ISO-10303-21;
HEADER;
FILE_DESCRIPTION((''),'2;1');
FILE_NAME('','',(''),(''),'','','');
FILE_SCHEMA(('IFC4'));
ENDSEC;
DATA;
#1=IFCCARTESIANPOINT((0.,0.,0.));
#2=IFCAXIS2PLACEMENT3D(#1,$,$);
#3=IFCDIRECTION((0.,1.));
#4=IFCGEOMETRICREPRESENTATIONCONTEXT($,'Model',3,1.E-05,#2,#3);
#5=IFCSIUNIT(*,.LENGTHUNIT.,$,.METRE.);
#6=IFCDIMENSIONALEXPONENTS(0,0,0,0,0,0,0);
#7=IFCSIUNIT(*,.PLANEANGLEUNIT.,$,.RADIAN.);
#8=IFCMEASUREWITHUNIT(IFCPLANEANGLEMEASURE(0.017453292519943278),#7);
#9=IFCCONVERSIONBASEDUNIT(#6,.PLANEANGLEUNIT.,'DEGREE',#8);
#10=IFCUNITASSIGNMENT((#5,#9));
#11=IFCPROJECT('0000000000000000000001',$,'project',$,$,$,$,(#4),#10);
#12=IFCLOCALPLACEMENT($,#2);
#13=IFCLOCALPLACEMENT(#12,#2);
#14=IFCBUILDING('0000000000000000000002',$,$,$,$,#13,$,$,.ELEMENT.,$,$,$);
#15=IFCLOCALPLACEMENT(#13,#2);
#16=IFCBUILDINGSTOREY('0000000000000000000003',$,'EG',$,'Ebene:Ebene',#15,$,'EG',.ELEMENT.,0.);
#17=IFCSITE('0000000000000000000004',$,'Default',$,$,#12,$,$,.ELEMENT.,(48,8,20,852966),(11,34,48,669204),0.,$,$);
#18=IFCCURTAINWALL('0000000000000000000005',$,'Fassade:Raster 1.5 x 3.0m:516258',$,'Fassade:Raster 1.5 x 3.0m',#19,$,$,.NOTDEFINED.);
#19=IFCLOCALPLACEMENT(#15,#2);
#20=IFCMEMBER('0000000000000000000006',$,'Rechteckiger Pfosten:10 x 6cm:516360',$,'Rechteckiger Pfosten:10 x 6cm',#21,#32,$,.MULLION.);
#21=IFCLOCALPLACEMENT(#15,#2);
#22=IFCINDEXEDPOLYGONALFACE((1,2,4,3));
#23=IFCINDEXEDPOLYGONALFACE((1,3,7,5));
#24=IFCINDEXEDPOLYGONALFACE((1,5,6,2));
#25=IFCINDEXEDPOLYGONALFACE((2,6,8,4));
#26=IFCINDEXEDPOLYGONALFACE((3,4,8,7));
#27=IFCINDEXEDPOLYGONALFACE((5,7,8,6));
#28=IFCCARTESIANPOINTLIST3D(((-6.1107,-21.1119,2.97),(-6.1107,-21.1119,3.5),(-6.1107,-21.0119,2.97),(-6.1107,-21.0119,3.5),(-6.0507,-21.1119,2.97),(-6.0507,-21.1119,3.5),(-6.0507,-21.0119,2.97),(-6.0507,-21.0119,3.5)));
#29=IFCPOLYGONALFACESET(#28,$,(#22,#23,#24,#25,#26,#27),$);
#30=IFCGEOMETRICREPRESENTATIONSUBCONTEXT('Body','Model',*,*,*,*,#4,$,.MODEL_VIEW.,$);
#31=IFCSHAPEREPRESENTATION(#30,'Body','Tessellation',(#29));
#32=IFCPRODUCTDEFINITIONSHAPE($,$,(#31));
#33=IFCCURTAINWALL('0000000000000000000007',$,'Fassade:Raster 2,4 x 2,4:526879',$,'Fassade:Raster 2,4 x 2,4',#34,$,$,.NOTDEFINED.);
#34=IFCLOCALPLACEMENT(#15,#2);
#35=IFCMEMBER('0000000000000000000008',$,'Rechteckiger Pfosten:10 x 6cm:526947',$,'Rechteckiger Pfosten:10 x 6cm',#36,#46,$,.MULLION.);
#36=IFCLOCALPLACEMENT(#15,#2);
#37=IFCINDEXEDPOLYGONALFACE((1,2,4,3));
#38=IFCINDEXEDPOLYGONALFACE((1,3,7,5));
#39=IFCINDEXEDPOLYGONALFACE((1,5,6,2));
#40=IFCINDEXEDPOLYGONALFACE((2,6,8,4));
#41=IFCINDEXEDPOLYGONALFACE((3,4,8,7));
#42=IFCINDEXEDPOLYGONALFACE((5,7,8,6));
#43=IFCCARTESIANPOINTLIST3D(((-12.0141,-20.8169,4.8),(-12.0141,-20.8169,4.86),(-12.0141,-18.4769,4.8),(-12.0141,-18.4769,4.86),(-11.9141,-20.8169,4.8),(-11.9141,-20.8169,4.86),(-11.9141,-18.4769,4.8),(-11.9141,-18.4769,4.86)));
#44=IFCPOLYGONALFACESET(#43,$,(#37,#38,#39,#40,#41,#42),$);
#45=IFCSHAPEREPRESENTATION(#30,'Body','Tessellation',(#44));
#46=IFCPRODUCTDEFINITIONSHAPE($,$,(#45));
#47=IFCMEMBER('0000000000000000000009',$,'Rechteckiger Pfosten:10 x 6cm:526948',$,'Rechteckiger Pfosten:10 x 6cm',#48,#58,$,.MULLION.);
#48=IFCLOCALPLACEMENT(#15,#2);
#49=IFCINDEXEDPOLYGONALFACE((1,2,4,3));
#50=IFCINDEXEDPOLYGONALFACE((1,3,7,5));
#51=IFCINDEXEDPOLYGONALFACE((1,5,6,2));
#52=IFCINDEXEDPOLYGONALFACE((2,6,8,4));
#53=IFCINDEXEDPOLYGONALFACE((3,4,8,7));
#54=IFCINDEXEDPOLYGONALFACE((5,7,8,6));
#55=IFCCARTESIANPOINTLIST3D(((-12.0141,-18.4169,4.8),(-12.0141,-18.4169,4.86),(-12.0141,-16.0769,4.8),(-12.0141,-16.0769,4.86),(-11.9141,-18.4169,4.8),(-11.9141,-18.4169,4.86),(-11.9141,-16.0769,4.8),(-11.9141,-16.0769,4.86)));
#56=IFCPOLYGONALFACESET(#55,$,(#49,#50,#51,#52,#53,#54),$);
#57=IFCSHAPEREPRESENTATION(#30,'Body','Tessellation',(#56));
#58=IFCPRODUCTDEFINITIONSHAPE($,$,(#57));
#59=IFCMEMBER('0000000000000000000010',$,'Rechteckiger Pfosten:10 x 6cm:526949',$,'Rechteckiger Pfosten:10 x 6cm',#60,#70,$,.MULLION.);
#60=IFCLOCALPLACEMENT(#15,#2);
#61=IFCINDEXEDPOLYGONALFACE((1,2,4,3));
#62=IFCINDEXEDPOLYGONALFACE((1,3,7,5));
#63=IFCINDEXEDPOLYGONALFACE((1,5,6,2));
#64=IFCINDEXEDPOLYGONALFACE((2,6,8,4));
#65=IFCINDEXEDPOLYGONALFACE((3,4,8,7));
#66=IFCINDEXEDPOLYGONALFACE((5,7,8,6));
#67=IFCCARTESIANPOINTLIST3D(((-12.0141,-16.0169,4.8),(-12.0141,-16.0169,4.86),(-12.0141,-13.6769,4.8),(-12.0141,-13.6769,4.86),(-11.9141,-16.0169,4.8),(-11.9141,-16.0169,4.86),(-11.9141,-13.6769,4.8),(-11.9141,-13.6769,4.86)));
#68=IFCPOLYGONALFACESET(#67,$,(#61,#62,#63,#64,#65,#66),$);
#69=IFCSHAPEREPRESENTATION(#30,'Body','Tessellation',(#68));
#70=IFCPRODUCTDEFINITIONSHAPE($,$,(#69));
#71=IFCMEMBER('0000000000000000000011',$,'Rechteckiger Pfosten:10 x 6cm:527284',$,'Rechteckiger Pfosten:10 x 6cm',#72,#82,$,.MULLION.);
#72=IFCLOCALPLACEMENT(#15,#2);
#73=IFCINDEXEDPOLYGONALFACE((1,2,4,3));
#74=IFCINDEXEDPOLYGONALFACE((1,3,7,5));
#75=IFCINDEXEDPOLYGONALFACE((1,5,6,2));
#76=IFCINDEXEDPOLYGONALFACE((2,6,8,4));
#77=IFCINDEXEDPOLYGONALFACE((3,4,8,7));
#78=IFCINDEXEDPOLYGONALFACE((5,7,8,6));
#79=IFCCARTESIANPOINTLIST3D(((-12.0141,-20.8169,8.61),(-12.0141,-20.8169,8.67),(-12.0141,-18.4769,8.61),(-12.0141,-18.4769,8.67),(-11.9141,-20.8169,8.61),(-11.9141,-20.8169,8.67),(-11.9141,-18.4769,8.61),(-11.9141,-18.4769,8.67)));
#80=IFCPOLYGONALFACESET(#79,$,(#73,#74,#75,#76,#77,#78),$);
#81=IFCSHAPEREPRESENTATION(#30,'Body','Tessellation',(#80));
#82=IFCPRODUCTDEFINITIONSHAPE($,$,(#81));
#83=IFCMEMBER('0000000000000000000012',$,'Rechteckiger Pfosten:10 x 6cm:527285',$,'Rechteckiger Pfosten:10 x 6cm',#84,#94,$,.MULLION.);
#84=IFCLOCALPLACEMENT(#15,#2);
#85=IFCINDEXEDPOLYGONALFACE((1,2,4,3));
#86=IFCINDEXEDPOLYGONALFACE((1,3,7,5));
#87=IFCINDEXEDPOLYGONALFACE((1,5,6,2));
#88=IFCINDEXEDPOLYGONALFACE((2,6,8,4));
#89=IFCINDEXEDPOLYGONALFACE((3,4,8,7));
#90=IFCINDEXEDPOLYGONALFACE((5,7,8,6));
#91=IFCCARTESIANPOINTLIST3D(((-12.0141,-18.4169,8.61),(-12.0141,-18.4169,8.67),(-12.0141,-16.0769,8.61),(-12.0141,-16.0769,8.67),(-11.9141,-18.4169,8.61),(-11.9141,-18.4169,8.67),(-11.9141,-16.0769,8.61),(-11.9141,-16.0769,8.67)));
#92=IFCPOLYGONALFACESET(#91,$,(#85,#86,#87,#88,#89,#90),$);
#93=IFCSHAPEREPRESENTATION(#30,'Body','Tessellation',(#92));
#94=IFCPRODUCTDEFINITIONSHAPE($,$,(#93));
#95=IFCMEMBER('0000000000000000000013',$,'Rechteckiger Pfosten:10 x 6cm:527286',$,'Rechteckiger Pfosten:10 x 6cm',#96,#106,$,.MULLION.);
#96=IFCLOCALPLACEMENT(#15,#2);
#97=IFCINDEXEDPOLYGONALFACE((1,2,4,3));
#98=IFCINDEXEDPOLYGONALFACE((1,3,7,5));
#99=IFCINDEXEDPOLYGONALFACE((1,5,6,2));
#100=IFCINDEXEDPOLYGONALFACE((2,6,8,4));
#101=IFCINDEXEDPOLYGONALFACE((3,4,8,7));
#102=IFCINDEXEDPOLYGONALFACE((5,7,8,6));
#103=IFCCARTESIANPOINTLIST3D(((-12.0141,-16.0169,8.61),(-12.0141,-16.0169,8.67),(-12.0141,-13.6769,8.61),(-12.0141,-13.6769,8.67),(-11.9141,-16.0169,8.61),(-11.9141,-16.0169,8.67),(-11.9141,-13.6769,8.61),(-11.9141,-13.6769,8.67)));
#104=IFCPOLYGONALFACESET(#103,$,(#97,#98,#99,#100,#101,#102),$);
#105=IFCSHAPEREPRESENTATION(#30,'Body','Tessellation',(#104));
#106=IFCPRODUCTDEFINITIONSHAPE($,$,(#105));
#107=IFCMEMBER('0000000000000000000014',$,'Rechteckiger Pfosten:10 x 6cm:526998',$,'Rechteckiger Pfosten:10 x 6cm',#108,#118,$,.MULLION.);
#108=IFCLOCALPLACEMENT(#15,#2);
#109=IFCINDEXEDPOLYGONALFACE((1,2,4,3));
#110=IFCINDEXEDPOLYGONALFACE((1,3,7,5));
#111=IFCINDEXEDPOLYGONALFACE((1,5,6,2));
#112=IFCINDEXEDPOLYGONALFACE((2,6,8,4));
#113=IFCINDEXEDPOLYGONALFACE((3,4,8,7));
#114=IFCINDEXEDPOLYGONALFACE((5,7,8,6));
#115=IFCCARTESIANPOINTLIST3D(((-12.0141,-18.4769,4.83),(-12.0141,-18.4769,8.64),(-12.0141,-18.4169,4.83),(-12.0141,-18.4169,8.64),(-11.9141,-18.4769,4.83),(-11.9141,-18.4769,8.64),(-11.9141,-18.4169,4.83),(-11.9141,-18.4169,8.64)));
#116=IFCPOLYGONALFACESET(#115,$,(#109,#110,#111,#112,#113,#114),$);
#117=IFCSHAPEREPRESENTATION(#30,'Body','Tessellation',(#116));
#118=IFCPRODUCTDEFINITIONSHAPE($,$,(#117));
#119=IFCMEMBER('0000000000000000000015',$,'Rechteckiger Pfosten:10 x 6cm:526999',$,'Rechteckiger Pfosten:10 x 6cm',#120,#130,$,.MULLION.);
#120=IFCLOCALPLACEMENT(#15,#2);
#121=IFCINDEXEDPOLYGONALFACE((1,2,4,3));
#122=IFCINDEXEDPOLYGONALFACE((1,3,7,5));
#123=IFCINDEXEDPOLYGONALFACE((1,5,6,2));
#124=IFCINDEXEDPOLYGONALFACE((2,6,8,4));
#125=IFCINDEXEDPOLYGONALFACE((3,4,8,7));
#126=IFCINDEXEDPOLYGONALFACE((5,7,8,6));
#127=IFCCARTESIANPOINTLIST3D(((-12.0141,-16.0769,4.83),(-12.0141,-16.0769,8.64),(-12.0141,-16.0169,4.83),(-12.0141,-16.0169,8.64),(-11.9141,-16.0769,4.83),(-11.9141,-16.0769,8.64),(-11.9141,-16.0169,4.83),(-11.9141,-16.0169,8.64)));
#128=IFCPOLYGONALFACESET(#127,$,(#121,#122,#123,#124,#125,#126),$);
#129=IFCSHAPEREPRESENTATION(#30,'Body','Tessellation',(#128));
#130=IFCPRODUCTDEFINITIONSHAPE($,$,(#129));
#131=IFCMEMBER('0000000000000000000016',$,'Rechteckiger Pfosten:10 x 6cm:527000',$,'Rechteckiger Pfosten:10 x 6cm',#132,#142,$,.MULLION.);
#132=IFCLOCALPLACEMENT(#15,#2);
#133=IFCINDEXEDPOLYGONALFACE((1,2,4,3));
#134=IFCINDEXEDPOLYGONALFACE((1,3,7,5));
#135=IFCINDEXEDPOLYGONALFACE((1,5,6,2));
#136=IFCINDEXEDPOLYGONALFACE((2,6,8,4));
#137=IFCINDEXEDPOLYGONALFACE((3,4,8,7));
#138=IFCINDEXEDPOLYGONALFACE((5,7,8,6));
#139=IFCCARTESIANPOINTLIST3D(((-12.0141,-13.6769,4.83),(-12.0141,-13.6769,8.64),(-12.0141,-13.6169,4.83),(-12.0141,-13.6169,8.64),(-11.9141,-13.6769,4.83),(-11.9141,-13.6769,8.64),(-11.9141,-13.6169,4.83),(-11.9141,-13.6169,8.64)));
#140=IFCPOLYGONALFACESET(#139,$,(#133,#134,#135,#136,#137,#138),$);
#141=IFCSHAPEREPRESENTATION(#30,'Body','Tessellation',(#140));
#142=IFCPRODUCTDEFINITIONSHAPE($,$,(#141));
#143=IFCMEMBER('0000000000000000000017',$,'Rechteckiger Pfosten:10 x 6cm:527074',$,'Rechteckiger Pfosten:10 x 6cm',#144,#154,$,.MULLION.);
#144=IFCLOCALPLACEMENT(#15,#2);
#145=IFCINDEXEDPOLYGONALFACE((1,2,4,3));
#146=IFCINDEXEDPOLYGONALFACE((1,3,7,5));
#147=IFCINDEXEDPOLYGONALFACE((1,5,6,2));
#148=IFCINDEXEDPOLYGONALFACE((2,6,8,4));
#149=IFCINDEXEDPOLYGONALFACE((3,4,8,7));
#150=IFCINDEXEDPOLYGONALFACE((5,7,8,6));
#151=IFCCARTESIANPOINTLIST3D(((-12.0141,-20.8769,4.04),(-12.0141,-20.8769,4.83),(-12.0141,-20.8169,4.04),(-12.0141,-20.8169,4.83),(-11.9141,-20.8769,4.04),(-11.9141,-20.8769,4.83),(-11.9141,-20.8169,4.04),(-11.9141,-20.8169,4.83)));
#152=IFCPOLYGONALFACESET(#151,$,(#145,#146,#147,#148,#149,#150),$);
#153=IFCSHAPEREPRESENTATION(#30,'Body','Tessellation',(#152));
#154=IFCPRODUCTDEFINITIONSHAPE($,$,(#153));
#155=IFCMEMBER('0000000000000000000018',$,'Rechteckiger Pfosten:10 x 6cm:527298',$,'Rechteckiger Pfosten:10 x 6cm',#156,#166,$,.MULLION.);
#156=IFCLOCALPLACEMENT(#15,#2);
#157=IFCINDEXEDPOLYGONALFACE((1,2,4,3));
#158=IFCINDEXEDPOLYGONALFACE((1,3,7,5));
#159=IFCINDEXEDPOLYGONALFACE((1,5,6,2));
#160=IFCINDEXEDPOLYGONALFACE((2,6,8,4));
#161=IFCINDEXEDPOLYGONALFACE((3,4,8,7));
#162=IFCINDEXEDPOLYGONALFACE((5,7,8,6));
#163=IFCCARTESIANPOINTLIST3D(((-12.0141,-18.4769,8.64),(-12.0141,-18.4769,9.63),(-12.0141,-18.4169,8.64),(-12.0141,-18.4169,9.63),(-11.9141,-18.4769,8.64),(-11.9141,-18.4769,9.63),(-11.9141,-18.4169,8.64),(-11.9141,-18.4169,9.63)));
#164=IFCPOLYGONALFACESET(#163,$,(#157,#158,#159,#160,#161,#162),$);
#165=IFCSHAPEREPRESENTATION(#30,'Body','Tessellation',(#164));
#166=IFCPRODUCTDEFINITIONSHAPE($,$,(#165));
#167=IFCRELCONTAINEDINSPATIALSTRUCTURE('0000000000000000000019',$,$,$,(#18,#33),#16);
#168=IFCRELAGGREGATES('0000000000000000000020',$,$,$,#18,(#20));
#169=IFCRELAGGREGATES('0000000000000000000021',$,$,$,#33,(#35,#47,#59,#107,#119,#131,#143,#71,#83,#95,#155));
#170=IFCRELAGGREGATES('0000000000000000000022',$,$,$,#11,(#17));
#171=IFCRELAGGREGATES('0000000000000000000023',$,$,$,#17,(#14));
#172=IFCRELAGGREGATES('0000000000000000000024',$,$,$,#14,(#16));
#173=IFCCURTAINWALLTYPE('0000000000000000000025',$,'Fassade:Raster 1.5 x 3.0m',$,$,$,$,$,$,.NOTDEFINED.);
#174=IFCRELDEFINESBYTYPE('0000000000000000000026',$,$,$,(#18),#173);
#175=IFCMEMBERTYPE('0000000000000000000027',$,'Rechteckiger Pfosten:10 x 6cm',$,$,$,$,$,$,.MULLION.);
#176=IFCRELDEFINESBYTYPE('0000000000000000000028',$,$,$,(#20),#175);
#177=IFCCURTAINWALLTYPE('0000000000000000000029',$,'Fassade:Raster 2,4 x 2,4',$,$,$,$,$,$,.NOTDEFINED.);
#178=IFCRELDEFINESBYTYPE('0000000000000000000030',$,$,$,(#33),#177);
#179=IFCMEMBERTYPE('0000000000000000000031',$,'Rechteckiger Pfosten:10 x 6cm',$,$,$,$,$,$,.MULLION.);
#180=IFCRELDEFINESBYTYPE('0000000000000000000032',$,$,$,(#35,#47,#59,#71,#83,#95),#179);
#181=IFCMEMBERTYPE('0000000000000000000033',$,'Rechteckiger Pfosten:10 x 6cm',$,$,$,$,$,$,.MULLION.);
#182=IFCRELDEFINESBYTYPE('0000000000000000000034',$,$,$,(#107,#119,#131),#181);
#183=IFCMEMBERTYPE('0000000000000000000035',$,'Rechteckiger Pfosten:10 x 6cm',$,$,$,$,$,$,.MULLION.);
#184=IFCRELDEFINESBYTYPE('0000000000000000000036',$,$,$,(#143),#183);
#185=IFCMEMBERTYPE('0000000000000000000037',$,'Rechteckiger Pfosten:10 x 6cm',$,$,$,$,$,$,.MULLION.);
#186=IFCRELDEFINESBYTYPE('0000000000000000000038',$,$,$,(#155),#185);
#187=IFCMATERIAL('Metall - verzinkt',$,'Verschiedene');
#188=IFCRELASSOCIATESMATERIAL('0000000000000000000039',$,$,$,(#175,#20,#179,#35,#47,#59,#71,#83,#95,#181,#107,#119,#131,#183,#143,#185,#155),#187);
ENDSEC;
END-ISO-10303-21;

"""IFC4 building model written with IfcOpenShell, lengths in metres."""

from ifc_helpers import new_model, entity, si_unit, converted_unit, direction, frame, origin, place, context, subcontext, project, spatial, indexed_curve, outline, extrude, source, transform, mapped, material, type_object, type_shapes, element, aggregate, save


model = new_model("IFC4")

# Units and contexts
model_context = context("Model", 3, precision=1e-05, world=origin(), true_north=direction((0.0, 1.0)))
body_context = subcontext(model_context, "Body", "Model", "MODEL_VIEW")
ifc_project = project(units=[si_unit("LENGTHUNIT", "METRE"), converted_unit("PLANEANGLEUNIT", "DEGREE", entity("IfcPlaneAngleMeasure", 0.017453292519943278), si_unit("PLANEANGLEUNIT", "RADIAN"), dimensions=[0, 0, 0, 0, 0, 0, 0])], contexts=[model_context])

# Site, building, storey
site_placement = place(None, origin())
site = spatial("IfcSite", under=ifc_project, at=site_placement, Name="Default", CompositionType="ELEMENT", RefLatitude=(48, 8, 20, 852966), RefLongitude=(11, 34, 48, 669204), RefElevation=0.0)
building_placement = place(site_placement, origin())
building = spatial("IfcBuilding", under=site, at=building_placement, CompositionType="ELEMENT")
storey_placement = place(building_placement, origin())
storey = spatial("IfcBuildingStorey", under=building, at=storey_placement, Name="EG", ObjectType="Ebene:Ebene", LongName="EG", CompositionType="ELEMENT", Elevation=0.0)

# Curtain wall, member
curtain_wall_type_1 = type_object("IfcCurtainWallType", Name="Fassade:Raster 1.5 x 3.0m", PredefinedType="NOTDEFINED")
curtain_wall_1_placement = place(storey_placement, origin())
curtain_wall_1 = element("IfcCurtainWall", 1, at=curtain_wall_1_placement, inside=storey, type_object=curtain_wall_type_1, Name="Fassade:Raster 1.5 x 3.0m:516258", ObjectType="Fassade:Raster 1.5 x 3.0m", PredefinedType="NOTDEFINED")
ifc_material_1 = material(Name="Metall - verzinkt", Category="Verschiedene")
member_type_1 = type_object("IfcMemberType", Name="Rechteckiger Pfosten:10 x 6cm", PredefinedType="MULLION", material=ifc_material_1)
shared_shape_1 = source(origin(), body_context, "Body", "SweptSolid", [
    extrude(outline(indexed_curve([(-0.03, -0.05), (0.03, -0.05), (0.03, 0.05), (-0.03, 0.05), (-0.03, -0.05)], self_intersect=False)), frame((0.0, 0.0, -0.53), z_axis=(0.0, 0.0, 1.0), x_axis=(-1.0, 0.0, 0.0)), (0.0, 0.0, 1.0), 0.53),
])
type_shapes(member_type_1, [shared_shape_1])
member_1_placement = place(curtain_wall_1_placement, frame((-6.0807, -21.0619, 2.97), z_axis=(0.0, 0.0, -1.0), x_axis=(1.0, 0.0, 0.0)))
member_1 = element("IfcMember", 2, at=member_1_placement, type_object=member_type_1, material=ifc_material_1, Name="Rechteckiger Pfosten:10 x 6cm:516360", ObjectType="Rechteckiger Pfosten:10 x 6cm", PredefinedType="MULLION", context=body_context, shape_type="MappedRepresentation", body=[
    mapped(shared_shape_1, transform((0.0, 0.0, 0.0), scale=1.0)),
])

# Curtain wall, members
curtain_wall_type_2 = type_object("IfcCurtainWallType", Name="Fassade:Raster 2,4 x 2,4", PredefinedType="NOTDEFINED")
curtain_wall_2_placement = place(storey_placement, origin())
curtain_wall_2 = element("IfcCurtainWall", 3, at=curtain_wall_2_placement, inside=storey, type_object=curtain_wall_type_2, Name="Fassade:Raster 2,4 x 2,4:526879", ObjectType="Fassade:Raster 2,4 x 2,4", PredefinedType="NOTDEFINED")
member_type_2 = type_object("IfcMemberType", Name="Rechteckiger Pfosten:10 x 6cm", PredefinedType="MULLION", material=ifc_material_1)
shared_shape_2 = source(origin(), body_context, "Body", "SweptSolid", [
    extrude(outline(indexed_curve([(-0.03, -0.05), (0.03, -0.05), (0.03, 0.05), (-0.03, 0.05), (-0.03, -0.05)], self_intersect=False)), frame((0.0, 0.0, -2.34), z_axis=(0.0, 0.0, 1.0), x_axis=(-1.0, 0.0, 0.0)), (0.0, 0.0, 1.0), 2.34),
])
type_shapes(member_type_2, [shared_shape_2])
member_2_placement = place(curtain_wall_2_placement, frame((-11.9641, -18.4769, 4.83), z_axis=(0.0, 1.0, 0.0), x_axis=(0.0, 0.0, 1.0)))
member_2 = element("IfcMember", 4, at=member_2_placement, type_object=member_type_2, material=ifc_material_1, Name="Rechteckiger Pfosten:10 x 6cm:526947", ObjectType="Rechteckiger Pfosten:10 x 6cm", PredefinedType="MULLION", context=body_context, shape_type="MappedRepresentation", body=[
    mapped(shared_shape_2, transform((0.0, 0.0, 0.0), scale=1.0)),
])
member_3_placement = place(curtain_wall_2_placement, frame((-11.9641, -16.0769, 4.83), z_axis=(0.0, 1.0, 0.0), x_axis=(0.0, 0.0, 1.0)))
member_3 = element("IfcMember", 5, at=member_3_placement, type_object=member_type_2, material=ifc_material_1, Name="Rechteckiger Pfosten:10 x 6cm:526948", ObjectType="Rechteckiger Pfosten:10 x 6cm", PredefinedType="MULLION", context=body_context, shape_type="MappedRepresentation", body=[
    mapped(shared_shape_2, transform((0.0, 0.0, 0.0), scale=1.0)),
])
member_4_placement = place(curtain_wall_2_placement, frame((-11.9641, -13.6769, 4.83), z_axis=(0.0, 1.0, 0.0), x_axis=(0.0, 0.0, 1.0)))
member_4 = element("IfcMember", 6, at=member_4_placement, type_object=member_type_2, material=ifc_material_1, Name="Rechteckiger Pfosten:10 x 6cm:526949", ObjectType="Rechteckiger Pfosten:10 x 6cm", PredefinedType="MULLION", context=body_context, shape_type="MappedRepresentation", body=[
    mapped(shared_shape_2, transform((0.0, 0.0, 0.0), scale=1.0)),
])
member_5_placement = place(curtain_wall_2_placement, frame((-11.9641, -18.4769, 8.64), z_axis=(0.0, 1.0, 0.0), x_axis=(0.0, 0.0, 1.0)))
member_5 = element("IfcMember", 7, at=member_5_placement, type_object=member_type_2, material=ifc_material_1, Name="Rechteckiger Pfosten:10 x 6cm:527284", ObjectType="Rechteckiger Pfosten:10 x 6cm", PredefinedType="MULLION", context=body_context, shape_type="MappedRepresentation", body=[
    mapped(shared_shape_2, transform((0.0, 0.0, 0.0), scale=1.0)),
])
member_6_placement = place(curtain_wall_2_placement, frame((-11.9641, -16.0769, 8.64), z_axis=(0.0, 1.0, 0.0), x_axis=(0.0, 0.0, 1.0)))
member_6 = element("IfcMember", 8, at=member_6_placement, type_object=member_type_2, material=ifc_material_1, Name="Rechteckiger Pfosten:10 x 6cm:527285", ObjectType="Rechteckiger Pfosten:10 x 6cm", PredefinedType="MULLION", context=body_context, shape_type="MappedRepresentation", body=[
    mapped(shared_shape_2, transform((0.0, 0.0, 0.0), scale=1.0)),
])
member_7_placement = place(curtain_wall_2_placement, frame((-11.9641, -13.6769, 8.64), z_axis=(0.0, 1.0, 0.0), x_axis=(0.0, 0.0, 1.0)))
member_7 = element("IfcMember", 9, at=member_7_placement, type_object=member_type_2, material=ifc_material_1, Name="Rechteckiger Pfosten:10 x 6cm:527286", ObjectType="Rechteckiger Pfosten:10 x 6cm", PredefinedType="MULLION", context=body_context, shape_type="MappedRepresentation", body=[
    mapped(shared_shape_2, transform((0.0, 0.0, 0.0), scale=1.0)),
])
member_type_3 = type_object("IfcMemberType", Name="Rechteckiger Pfosten:10 x 6cm", PredefinedType="MULLION", material=ifc_material_1)
shared_shape_3 = source(origin(), body_context, "Body", "SweptSolid", [
    extrude(outline(indexed_curve([(-0.03, -0.05), (0.03, -0.05), (0.03, 0.05), (-0.03, 0.05), (-0.03, -0.05)], self_intersect=False)), frame((0.0, 0.0, -3.81), z_axis=(0.0, 0.0, 1.0), x_axis=(-1.0, 0.0, 0.0)), (0.0, 0.0, 1.0), 3.81),
])
type_shapes(member_type_3, [shared_shape_3])
member_8_placement = place(curtain_wall_2_placement, frame((-11.9641, -18.4469, 4.83), z_axis=(0.0, 0.0, -1.0), x_axis=(0.0, 1.0, 0.0)))
member_8 = element("IfcMember", 10, at=member_8_placement, type_object=member_type_3, material=ifc_material_1, Name="Rechteckiger Pfosten:10 x 6cm:526998", ObjectType="Rechteckiger Pfosten:10 x 6cm", PredefinedType="MULLION", context=body_context, shape_type="MappedRepresentation", body=[
    mapped(shared_shape_3, transform((0.0, 0.0, 0.0), scale=1.0)),
])
member_9_placement = place(curtain_wall_2_placement, frame((-11.9641, -16.0469, 4.83), z_axis=(0.0, 0.0, -1.0), x_axis=(0.0, 1.0, 0.0)))
member_9 = element("IfcMember", 11, at=member_9_placement, type_object=member_type_3, material=ifc_material_1, Name="Rechteckiger Pfosten:10 x 6cm:526999", ObjectType="Rechteckiger Pfosten:10 x 6cm", PredefinedType="MULLION", context=body_context, shape_type="MappedRepresentation", body=[
    mapped(shared_shape_3, transform((0.0, 0.0, 0.0), scale=1.0)),
])
member_10_placement = place(curtain_wall_2_placement, frame((-11.9641, -13.6469, 4.83), z_axis=(0.0, 0.0, -1.0), x_axis=(0.0, 1.0, 0.0)))
member_10 = element("IfcMember", 12, at=member_10_placement, type_object=member_type_3, material=ifc_material_1, Name="Rechteckiger Pfosten:10 x 6cm:527000", ObjectType="Rechteckiger Pfosten:10 x 6cm", PredefinedType="MULLION", context=body_context, shape_type="MappedRepresentation", body=[
    mapped(shared_shape_3, transform((0.0, 0.0, 0.0), scale=1.0)),
])
member_type_4 = type_object("IfcMemberType", Name="Rechteckiger Pfosten:10 x 6cm", PredefinedType="MULLION", material=ifc_material_1)
shared_shape_4 = source(origin(), body_context, "Body", "SweptSolid", [
    extrude(outline(indexed_curve([(-0.03, -0.05), (0.03, -0.05), (0.03, 0.05), (-0.03, 0.05), (-0.03, -0.05)], self_intersect=False)), frame((-0.03, 0.0, -0.79), z_axis=(0.0, 0.0, 1.0), x_axis=(-1.0, 0.0, 0.0)), (0.0, 0.0, 1.0), 0.79),
])
type_shapes(member_type_4, [shared_shape_4])
member_11_placement = place(curtain_wall_2_placement, frame((-11.9641, -20.8769, 4.83), z_axis=(0.0, 0.0, 1.0), x_axis=(0.0, -1.0, 0.0)))
member_11 = element("IfcMember", 13, at=member_11_placement, type_object=member_type_4, material=ifc_material_1, Name="Rechteckiger Pfosten:10 x 6cm:527074", ObjectType="Rechteckiger Pfosten:10 x 6cm", PredefinedType="MULLION", context=body_context, shape_type="MappedRepresentation", body=[
    mapped(shared_shape_4, transform((0.0, 0.0, 0.0), scale=1.0)),
])
member_type_5 = type_object("IfcMemberType", Name="Rechteckiger Pfosten:10 x 6cm", PredefinedType="MULLION", material=ifc_material_1)
shared_shape_5 = source(origin(), body_context, "Body", "SweptSolid", [
    extrude(outline(indexed_curve([(-0.03, -0.05), (0.03, -0.05), (0.03, 0.05), (-0.03, 0.05), (-0.03, -0.05)], self_intersect=False)), frame((0.0, 0.0, -0.99), z_axis=(0.0, 0.0, 1.0), x_axis=(-1.0, 0.0, 0.0)), (0.0, 0.0, 1.0), 0.99),
])
type_shapes(member_type_5, [shared_shape_5])
member_12_placement = place(curtain_wall_2_placement, frame((-11.9641, -18.4469, 8.64), z_axis=(0.0, 0.0, -1.0), x_axis=(0.0, 1.0, 0.0)))
member_12 = element("IfcMember", 14, at=member_12_placement, type_object=member_type_5, material=ifc_material_1, Name="Rechteckiger Pfosten:10 x 6cm:527298", ObjectType="Rechteckiger Pfosten:10 x 6cm", PredefinedType="MULLION", context=body_context, shape_type="MappedRepresentation", body=[
    mapped(shared_shape_5, transform((0.0, 0.0, 0.0), scale=1.0)),
])

aggregate(curtain_wall_1, [member_1])
aggregate(curtain_wall_2, [member_2, member_3, member_4, member_8, member_9, member_10, member_11, member_5, member_6, member_7, member_12])

save(model, "model.ifc")
